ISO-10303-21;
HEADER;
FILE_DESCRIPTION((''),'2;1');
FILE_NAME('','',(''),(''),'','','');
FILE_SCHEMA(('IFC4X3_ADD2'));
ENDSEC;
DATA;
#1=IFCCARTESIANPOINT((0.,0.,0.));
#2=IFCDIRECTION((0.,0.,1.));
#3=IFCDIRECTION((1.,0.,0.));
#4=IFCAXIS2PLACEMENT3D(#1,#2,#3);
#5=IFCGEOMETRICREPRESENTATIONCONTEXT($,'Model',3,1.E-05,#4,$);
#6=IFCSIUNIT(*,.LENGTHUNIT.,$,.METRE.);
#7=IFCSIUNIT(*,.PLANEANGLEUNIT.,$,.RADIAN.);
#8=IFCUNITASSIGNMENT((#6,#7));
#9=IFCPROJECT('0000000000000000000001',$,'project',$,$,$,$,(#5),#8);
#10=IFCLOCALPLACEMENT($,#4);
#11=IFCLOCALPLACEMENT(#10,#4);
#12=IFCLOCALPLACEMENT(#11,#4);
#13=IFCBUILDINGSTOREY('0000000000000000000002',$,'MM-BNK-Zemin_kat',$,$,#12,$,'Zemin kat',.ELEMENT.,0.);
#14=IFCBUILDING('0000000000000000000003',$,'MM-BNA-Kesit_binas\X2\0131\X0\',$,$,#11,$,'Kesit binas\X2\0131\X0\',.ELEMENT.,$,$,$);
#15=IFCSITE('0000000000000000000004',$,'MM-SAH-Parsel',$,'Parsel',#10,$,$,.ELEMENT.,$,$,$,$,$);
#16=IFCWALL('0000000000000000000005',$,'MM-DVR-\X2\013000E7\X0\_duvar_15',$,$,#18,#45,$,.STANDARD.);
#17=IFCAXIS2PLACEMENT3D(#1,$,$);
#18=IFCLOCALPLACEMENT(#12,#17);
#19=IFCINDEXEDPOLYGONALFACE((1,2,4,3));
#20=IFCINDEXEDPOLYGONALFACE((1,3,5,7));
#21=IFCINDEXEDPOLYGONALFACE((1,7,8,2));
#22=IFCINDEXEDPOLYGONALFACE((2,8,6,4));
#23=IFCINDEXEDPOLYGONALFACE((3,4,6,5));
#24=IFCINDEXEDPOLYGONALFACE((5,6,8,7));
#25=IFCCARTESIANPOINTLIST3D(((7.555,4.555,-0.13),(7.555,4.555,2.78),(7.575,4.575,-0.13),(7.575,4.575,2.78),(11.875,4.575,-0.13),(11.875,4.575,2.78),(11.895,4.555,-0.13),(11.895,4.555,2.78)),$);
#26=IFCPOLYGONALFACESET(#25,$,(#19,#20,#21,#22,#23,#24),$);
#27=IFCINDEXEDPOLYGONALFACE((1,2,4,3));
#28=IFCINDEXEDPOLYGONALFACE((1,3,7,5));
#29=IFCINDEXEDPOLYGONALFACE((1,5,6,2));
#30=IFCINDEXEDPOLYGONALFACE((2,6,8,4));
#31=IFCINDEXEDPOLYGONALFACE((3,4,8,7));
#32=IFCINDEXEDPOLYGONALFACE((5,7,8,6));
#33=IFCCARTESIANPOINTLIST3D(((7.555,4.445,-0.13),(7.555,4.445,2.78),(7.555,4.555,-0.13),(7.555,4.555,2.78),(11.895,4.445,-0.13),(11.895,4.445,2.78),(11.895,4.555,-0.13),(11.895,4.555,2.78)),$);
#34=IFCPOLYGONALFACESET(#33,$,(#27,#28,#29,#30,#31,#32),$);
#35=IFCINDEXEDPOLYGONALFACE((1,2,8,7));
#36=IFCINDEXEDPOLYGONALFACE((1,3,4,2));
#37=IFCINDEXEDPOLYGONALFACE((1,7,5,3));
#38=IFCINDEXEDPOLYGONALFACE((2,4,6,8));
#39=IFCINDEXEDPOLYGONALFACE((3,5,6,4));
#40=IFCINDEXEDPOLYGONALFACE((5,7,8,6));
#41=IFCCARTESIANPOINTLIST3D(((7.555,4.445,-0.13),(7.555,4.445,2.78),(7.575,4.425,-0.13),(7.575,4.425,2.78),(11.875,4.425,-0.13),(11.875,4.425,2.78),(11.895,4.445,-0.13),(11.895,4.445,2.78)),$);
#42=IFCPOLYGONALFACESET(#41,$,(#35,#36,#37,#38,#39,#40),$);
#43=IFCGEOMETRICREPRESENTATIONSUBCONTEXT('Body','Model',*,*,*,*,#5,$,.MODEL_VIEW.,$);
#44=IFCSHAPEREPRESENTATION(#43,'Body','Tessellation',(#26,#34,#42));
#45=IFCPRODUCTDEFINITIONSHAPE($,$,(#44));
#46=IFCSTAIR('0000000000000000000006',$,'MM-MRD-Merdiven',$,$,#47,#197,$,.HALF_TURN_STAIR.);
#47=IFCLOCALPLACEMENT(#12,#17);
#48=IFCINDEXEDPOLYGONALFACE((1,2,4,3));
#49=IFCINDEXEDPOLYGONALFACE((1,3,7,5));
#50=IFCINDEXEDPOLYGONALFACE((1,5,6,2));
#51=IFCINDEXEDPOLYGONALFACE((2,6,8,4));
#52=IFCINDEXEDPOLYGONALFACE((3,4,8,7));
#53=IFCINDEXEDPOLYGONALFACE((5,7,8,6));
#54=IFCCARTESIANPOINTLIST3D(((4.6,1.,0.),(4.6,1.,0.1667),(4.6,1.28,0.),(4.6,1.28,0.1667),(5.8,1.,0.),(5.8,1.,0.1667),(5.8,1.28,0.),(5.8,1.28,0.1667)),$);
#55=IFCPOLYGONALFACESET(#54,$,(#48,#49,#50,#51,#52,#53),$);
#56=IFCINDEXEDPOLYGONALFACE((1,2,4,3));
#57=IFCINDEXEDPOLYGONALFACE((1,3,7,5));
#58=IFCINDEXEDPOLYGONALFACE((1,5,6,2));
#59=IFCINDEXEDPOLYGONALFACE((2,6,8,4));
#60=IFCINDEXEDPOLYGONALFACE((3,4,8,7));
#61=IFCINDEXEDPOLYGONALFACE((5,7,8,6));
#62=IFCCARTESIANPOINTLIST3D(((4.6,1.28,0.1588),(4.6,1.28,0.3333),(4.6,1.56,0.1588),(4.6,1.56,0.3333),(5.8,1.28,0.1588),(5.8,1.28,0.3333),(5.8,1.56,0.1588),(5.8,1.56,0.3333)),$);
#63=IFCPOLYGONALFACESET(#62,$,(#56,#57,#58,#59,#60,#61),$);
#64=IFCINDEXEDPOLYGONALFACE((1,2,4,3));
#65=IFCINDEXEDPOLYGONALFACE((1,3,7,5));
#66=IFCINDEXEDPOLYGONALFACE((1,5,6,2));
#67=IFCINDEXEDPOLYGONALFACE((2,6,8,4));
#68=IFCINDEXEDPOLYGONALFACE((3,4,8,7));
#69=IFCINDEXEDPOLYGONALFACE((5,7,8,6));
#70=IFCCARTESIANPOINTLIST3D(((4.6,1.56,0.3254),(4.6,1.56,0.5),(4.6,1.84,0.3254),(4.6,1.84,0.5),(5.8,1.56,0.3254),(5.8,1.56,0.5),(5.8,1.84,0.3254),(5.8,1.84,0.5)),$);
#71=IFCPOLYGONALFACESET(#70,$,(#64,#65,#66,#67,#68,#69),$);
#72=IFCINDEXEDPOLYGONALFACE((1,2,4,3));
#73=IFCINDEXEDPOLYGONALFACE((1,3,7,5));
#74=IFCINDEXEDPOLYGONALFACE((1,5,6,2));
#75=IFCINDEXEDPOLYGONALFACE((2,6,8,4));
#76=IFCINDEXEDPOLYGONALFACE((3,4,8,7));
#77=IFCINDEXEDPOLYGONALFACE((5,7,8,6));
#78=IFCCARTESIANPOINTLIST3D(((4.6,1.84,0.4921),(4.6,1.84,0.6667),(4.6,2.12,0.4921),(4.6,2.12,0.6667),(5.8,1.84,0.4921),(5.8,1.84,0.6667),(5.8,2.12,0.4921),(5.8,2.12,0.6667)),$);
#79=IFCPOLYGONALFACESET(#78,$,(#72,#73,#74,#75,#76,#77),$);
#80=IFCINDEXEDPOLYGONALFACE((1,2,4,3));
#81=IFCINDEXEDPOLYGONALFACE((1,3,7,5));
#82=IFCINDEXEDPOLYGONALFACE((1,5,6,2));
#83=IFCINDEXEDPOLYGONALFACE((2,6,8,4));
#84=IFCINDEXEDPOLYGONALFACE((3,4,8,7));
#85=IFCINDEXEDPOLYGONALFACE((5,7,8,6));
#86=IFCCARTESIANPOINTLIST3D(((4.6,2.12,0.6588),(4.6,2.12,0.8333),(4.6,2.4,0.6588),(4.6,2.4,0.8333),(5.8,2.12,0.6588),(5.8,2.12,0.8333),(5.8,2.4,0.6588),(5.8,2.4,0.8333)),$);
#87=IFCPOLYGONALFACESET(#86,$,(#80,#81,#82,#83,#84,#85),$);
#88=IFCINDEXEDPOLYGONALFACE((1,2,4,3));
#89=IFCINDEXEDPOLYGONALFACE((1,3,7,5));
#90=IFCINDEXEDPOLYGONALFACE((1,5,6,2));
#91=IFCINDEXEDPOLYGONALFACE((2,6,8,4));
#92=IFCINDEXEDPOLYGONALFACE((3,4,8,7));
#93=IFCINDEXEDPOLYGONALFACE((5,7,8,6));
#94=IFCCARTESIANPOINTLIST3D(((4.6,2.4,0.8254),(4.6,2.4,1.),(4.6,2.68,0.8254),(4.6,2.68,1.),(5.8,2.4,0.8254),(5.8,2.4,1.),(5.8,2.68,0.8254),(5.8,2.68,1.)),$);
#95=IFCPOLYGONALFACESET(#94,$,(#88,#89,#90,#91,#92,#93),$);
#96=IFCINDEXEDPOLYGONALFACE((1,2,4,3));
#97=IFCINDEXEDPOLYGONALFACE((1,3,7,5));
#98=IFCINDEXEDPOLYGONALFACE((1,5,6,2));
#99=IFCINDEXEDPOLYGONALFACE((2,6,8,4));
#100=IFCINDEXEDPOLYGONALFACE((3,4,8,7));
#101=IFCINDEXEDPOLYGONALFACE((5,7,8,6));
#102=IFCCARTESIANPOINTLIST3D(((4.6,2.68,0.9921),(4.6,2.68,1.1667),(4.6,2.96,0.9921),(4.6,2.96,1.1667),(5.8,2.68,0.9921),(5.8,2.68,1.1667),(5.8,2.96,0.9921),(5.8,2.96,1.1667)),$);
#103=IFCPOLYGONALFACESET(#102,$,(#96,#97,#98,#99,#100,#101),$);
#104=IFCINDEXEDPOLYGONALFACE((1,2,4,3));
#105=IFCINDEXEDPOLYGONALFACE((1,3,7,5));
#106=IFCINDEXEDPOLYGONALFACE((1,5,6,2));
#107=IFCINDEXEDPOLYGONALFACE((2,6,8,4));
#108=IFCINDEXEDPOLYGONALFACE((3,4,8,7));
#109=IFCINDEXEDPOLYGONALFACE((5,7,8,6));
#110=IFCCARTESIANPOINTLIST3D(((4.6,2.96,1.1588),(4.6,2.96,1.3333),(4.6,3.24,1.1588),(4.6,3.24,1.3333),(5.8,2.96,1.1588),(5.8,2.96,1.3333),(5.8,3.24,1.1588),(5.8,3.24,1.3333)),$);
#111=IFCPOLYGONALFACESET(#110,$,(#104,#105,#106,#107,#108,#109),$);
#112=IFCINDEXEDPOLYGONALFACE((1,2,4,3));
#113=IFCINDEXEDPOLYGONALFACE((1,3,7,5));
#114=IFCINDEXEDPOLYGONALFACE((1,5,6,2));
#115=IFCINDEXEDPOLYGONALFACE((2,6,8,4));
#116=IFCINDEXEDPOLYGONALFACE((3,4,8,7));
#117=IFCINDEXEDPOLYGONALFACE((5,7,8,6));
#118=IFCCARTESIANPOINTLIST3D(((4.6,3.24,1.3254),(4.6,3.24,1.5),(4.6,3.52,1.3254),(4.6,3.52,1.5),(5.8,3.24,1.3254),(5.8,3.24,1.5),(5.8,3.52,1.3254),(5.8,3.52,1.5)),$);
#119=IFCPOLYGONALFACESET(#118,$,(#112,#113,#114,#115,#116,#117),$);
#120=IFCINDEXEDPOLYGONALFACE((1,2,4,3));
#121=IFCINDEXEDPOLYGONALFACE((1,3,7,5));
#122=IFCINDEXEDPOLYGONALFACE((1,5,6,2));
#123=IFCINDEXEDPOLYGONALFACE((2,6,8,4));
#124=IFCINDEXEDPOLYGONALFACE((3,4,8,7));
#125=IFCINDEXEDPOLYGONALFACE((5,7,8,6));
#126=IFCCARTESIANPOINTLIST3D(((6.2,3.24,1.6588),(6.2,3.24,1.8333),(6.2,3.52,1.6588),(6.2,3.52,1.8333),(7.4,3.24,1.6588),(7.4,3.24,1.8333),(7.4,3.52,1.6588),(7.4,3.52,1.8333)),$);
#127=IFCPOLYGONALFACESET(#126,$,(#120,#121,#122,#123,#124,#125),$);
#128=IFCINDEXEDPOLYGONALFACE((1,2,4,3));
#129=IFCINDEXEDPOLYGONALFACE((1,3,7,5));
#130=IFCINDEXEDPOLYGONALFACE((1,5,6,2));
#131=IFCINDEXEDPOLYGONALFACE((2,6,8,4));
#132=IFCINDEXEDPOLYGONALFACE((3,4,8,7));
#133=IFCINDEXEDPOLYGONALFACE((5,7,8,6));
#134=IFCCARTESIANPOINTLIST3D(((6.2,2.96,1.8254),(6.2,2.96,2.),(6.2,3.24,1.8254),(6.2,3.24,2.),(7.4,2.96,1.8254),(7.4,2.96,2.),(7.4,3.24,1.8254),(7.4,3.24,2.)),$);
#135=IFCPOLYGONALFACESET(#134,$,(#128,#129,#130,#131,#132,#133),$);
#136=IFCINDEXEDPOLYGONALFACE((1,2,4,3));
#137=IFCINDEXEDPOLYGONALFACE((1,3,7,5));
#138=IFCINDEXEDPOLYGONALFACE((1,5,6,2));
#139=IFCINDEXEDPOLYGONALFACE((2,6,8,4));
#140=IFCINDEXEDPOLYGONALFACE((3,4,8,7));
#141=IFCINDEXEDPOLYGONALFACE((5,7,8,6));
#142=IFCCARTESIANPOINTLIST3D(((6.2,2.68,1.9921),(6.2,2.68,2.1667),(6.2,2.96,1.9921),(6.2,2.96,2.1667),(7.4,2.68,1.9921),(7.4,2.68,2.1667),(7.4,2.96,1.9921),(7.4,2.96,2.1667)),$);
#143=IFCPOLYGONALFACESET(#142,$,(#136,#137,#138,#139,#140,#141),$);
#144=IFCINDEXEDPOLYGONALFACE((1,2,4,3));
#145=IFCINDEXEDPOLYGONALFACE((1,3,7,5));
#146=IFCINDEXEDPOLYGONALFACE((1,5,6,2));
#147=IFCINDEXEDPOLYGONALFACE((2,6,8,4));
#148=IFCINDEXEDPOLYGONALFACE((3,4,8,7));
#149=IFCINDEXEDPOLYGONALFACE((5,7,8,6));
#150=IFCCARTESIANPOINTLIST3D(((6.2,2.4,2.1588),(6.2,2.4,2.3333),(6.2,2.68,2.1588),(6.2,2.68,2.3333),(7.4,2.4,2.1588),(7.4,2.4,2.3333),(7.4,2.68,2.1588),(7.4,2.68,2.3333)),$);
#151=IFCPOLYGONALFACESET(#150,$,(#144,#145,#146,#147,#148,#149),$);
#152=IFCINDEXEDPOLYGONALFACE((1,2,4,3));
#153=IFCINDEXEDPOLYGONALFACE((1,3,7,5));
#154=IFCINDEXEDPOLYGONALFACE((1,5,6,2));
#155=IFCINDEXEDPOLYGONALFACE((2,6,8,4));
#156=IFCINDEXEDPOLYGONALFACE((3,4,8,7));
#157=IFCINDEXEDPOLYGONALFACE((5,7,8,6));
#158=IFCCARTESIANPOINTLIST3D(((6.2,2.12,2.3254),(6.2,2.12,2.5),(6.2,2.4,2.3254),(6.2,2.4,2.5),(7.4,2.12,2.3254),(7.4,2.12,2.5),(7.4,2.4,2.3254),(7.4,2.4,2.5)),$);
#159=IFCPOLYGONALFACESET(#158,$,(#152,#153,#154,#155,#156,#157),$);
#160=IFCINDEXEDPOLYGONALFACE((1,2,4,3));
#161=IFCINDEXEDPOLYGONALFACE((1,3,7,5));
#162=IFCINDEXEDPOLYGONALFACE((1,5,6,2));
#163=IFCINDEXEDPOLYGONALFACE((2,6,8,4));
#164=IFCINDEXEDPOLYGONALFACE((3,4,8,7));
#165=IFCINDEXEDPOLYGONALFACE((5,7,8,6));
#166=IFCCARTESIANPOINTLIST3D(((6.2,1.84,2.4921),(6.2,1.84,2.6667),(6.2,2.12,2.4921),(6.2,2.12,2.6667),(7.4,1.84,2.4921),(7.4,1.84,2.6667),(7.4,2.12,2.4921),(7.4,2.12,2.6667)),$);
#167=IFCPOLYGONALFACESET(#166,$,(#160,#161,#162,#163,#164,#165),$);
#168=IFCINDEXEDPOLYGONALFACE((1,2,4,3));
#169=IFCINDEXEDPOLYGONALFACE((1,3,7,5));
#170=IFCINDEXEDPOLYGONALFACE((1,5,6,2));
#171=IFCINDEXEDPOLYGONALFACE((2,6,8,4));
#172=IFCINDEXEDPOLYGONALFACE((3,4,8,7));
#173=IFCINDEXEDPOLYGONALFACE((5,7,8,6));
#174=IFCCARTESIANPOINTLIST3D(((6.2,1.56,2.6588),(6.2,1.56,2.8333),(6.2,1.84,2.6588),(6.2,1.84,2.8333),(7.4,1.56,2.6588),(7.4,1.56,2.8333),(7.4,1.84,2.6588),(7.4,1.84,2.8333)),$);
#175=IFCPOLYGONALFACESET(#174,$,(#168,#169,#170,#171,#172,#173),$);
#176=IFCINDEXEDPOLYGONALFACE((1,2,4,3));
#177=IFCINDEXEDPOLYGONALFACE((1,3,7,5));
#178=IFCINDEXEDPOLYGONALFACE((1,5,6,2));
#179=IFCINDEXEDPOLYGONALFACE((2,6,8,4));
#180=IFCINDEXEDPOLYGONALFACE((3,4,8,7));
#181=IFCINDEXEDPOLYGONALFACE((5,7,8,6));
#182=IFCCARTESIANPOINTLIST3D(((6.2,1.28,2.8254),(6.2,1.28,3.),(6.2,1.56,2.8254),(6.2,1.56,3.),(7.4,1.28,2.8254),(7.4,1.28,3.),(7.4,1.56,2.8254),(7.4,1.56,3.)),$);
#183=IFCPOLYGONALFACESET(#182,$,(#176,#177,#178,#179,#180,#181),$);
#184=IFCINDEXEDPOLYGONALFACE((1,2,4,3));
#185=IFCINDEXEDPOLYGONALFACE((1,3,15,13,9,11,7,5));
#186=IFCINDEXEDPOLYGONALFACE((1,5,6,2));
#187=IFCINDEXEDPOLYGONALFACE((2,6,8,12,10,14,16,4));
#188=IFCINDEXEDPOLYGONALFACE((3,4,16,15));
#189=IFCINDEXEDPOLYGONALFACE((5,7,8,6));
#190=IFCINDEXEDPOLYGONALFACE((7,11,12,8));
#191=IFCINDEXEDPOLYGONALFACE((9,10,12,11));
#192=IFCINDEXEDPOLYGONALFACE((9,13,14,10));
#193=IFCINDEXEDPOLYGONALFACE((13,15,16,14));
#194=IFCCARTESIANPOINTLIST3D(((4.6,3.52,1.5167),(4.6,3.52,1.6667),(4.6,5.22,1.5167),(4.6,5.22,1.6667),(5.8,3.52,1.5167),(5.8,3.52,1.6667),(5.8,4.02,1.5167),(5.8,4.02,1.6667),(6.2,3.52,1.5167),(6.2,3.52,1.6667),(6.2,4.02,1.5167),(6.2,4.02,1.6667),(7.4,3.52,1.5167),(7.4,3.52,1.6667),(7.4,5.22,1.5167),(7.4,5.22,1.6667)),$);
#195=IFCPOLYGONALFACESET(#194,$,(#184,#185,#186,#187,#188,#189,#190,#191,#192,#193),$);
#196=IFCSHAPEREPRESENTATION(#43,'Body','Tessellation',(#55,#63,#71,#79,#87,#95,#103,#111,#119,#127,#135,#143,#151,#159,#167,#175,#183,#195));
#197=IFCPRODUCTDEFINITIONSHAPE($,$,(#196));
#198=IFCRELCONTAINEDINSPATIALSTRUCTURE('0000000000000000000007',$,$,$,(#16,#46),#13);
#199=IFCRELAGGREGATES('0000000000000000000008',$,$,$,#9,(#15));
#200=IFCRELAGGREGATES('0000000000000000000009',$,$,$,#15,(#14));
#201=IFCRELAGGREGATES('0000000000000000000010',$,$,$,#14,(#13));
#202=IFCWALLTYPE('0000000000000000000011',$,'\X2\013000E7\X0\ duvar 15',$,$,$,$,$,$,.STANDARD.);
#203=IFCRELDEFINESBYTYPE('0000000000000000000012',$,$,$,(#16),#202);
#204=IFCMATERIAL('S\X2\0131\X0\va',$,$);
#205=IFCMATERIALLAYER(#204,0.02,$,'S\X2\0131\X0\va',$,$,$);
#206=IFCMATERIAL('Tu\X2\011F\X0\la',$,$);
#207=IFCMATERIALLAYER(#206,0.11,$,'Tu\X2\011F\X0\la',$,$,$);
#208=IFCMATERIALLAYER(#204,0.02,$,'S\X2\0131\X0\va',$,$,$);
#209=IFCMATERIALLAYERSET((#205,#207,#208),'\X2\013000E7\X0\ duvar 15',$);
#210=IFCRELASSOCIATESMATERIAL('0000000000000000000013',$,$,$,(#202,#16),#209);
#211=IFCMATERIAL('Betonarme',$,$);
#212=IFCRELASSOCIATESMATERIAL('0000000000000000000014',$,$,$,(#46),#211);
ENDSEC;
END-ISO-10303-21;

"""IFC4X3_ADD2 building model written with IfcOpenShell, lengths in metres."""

from ifc_helpers import new_model, si_unit, frame, origin, origin_with_axes, place, context, subcontext, project, spatial, polyline, outline, extrude, material, layer, layer_set, type_object, element, save


model = new_model("IFC4X3_ADD2")

# Units and contexts
model_context = context("Model", 3, precision=1e-05, world=origin_with_axes())
body_context = subcontext(model_context, "Body", "Model", "MODEL_VIEW")
ifc_project = project(units=[si_unit("LENGTHUNIT", "METRE"), si_unit("PLANEANGLEUNIT", "RADIAN")], contexts=[model_context])

# Site, building, storey
site_placement = place(None, origin_with_axes())
site = spatial("IfcSite", under=ifc_project, at=site_placement, Name="MM-SAH-Parsel", ObjectType="Parsel", CompositionType="ELEMENT")
building_placement = place(site_placement, origin_with_axes())
building = spatial("IfcBuilding", under=site, at=building_placement, Name="MM-BNA-Kesit_binası", LongName="Kesit binası", CompositionType="ELEMENT")
storey_placement = place(building_placement, origin_with_axes())
storey = spatial("IfcBuildingStorey", under=building, at=storey_placement, Name="MM-BNK-Zemin_kat", LongName="Zemin kat", CompositionType="ELEMENT", Elevation=0.0)

# Shared definitions
ifc_material_1 = material(Name="Betonarme")

# Shared definitions
ifc_material_2 = material(Name="Tuğla")

# Shared definitions
ifc_material_3 = material(Name="Sıva")
ifc_layer_1 = layer(ifc_material_3, 0.02, Name="Sıva")
ifc_layer_2 = layer(ifc_material_2, 0.11, Name="Tuğla")
ifc_layer_3 = layer(ifc_material_3, 0.02, Name="Sıva")
ifc_layer_set_1 = layer_set([ifc_layer_1, ifc_layer_2, ifc_layer_3], Name="İç duvar 15")
wall_type_1 = type_object("IfcWallType", Name="İç duvar 15", PredefinedType="STANDARD", material=ifc_layer_set_1)

# Wall
wall_1_placement = place(storey_placement, origin_with_axes())
element("IfcWall", 1, at=wall_1_placement, inside=storey, type_object=wall_type_1, material=ifc_layer_set_1, Name="MM-DVR-İç_duvar_15", PredefinedType="STANDARD", context=body_context, shape_type="SweptSolid", body=[
    extrude(outline(polyline([(7.575, 4.575), (11.875, 4.575), (11.895, 4.555), (7.555, 4.555), (7.575, 4.575)])), frame((0.0, 0.0, -0.13)), (0.0, 0.0, 1.0), 2.91),
    extrude(outline(polyline([(7.555, 4.555), (11.895, 4.555), (11.895, 4.445), (7.555, 4.445), (7.555, 4.555)])), frame((0.0, 0.0, -0.13)), (0.0, 0.0, 1.0), 2.91),
    extrude(outline(polyline([(7.555, 4.445), (11.895, 4.445), (11.875, 4.425), (7.575, 4.425), (7.555, 4.445)])), frame((0.0, 0.0, -0.13)), (0.0, 0.0, 1.0), 2.91),
])

# Stair
stair_placement = place(storey_placement, origin_with_axes())
element("IfcStair", 2, at=stair_placement, inside=storey, material=ifc_material_1, Name="MM-MRD-Merdiven", PredefinedType="HALF_TURN_STAIR", context=body_context, shape_type="SweptSolid", body=[
    extrude(outline(polyline([(5.8, 1.0), (5.8, 1.28), (4.6, 1.28), (4.6, 1.0), (5.8, 1.0)])), origin(), (0.0, 0.0, 1.0), 0.1667),
    extrude(outline(polyline([(5.8, 1.28), (5.8, 1.56), (4.6, 1.56), (4.6, 1.28), (5.8, 1.28)])), frame((0.0, 0.0, 0.1588)), (0.0, 0.0, 1.0), 0.1746),
    extrude(outline(polyline([(5.8, 1.56), (5.8, 1.84), (4.6, 1.84), (4.6, 1.56), (5.8, 1.56)])), frame((0.0, 0.0, 0.3254)), (0.0, 0.0, 1.0), 0.1746),
    extrude(outline(polyline([(5.8, 1.84), (5.8, 2.12), (4.6, 2.12), (4.6, 1.84), (5.8, 1.84)])), frame((0.0, 0.0, 0.4921)), (0.0, 0.0, 1.0), 0.1746),
    extrude(outline(polyline([(5.8, 2.12), (5.8, 2.4), (4.6, 2.4), (4.6, 2.12), (5.8, 2.12)])), frame((0.0, 0.0, 0.6588)), (0.0, 0.0, 1.0), 0.1746),
    extrude(outline(polyline([(5.8, 2.4), (5.8, 2.68), (4.6, 2.68), (4.6, 2.4), (5.8, 2.4)])), frame((0.0, 0.0, 0.8254)), (0.0, 0.0, 1.0), 0.1746),
    extrude(outline(polyline([(5.8, 2.68), (5.8, 2.96), (4.6, 2.96), (4.6, 2.68), (5.8, 2.68)])), frame((0.0, 0.0, 0.9921)), (0.0, 0.0, 1.0), 0.1746),
    extrude(outline(polyline([(5.8, 2.96), (5.8, 3.24), (4.6, 3.24), (4.6, 2.96), (5.8, 2.96)])), frame((0.0, 0.0, 1.1588)), (0.0, 0.0, 1.0), 0.1746),
    extrude(outline(polyline([(5.8, 3.24), (5.8, 3.52), (4.6, 3.52), (4.6, 3.24), (5.8, 3.24)])), frame((0.0, 0.0, 1.3254)), (0.0, 0.0, 1.0), 0.1746),
    extrude(outline(polyline([(6.2, 3.52), (6.2, 3.24), (7.4, 3.24), (7.4, 3.52), (6.2, 3.52)])), frame((0.0, 0.0, 1.6588)), (0.0, 0.0, 1.0), 0.1746),
    extrude(outline(polyline([(6.2, 3.24), (6.2, 2.96), (7.4, 2.96), (7.4, 3.24), (6.2, 3.24)])), frame((0.0, 0.0, 1.8254)), (0.0, 0.0, 1.0), 0.1746),
    extrude(outline(polyline([(6.2, 2.96), (6.2, 2.68), (7.4, 2.68), (7.4, 2.96), (6.2, 2.96)])), frame((0.0, 0.0, 1.9921)), (0.0, 0.0, 1.0), 0.1746),
    extrude(outline(polyline([(6.2, 2.68), (6.2, 2.4), (7.4, 2.4), (7.4, 2.68), (6.2, 2.68)])), frame((0.0, 0.0, 2.1588)), (0.0, 0.0, 1.0), 0.1746),
    extrude(outline(polyline([(6.2, 2.4), (6.2, 2.12), (7.4, 2.12), (7.4, 2.4), (6.2, 2.4)])), frame((0.0, 0.0, 2.3254)), (0.0, 0.0, 1.0), 0.1746),
    extrude(outline(polyline([(6.2, 2.12), (6.2, 1.84), (7.4, 1.84), (7.4, 2.12), (6.2, 2.12)])), frame((0.0, 0.0, 2.4921)), (0.0, 0.0, 1.0), 0.1746),
    extrude(outline(polyline([(6.2, 1.84), (6.2, 1.56), (7.4, 1.56), (7.4, 1.84), (6.2, 1.84)])), frame((0.0, 0.0, 2.6588)), (0.0, 0.0, 1.0), 0.1746),
    extrude(outline(polyline([(6.2, 1.56), (6.2, 1.28), (7.4, 1.28), (7.4, 1.56), (6.2, 1.56)])), frame((0.0, 0.0, 2.8254)), (0.0, 0.0, 1.0), 0.1746),
    extrude(outline(polyline([(4.6, 3.52), (4.6, 5.22), (7.4, 5.22), (7.4, 3.52), (6.2, 3.52), (6.2, 4.02), (5.8, 4.02), (5.8, 3.52), (4.6, 3.52)])), frame((0.0, 0.0, 1.5167)), (0.0, 0.0, 1.0), 0.15),
])

save(model, "model.ifc")
